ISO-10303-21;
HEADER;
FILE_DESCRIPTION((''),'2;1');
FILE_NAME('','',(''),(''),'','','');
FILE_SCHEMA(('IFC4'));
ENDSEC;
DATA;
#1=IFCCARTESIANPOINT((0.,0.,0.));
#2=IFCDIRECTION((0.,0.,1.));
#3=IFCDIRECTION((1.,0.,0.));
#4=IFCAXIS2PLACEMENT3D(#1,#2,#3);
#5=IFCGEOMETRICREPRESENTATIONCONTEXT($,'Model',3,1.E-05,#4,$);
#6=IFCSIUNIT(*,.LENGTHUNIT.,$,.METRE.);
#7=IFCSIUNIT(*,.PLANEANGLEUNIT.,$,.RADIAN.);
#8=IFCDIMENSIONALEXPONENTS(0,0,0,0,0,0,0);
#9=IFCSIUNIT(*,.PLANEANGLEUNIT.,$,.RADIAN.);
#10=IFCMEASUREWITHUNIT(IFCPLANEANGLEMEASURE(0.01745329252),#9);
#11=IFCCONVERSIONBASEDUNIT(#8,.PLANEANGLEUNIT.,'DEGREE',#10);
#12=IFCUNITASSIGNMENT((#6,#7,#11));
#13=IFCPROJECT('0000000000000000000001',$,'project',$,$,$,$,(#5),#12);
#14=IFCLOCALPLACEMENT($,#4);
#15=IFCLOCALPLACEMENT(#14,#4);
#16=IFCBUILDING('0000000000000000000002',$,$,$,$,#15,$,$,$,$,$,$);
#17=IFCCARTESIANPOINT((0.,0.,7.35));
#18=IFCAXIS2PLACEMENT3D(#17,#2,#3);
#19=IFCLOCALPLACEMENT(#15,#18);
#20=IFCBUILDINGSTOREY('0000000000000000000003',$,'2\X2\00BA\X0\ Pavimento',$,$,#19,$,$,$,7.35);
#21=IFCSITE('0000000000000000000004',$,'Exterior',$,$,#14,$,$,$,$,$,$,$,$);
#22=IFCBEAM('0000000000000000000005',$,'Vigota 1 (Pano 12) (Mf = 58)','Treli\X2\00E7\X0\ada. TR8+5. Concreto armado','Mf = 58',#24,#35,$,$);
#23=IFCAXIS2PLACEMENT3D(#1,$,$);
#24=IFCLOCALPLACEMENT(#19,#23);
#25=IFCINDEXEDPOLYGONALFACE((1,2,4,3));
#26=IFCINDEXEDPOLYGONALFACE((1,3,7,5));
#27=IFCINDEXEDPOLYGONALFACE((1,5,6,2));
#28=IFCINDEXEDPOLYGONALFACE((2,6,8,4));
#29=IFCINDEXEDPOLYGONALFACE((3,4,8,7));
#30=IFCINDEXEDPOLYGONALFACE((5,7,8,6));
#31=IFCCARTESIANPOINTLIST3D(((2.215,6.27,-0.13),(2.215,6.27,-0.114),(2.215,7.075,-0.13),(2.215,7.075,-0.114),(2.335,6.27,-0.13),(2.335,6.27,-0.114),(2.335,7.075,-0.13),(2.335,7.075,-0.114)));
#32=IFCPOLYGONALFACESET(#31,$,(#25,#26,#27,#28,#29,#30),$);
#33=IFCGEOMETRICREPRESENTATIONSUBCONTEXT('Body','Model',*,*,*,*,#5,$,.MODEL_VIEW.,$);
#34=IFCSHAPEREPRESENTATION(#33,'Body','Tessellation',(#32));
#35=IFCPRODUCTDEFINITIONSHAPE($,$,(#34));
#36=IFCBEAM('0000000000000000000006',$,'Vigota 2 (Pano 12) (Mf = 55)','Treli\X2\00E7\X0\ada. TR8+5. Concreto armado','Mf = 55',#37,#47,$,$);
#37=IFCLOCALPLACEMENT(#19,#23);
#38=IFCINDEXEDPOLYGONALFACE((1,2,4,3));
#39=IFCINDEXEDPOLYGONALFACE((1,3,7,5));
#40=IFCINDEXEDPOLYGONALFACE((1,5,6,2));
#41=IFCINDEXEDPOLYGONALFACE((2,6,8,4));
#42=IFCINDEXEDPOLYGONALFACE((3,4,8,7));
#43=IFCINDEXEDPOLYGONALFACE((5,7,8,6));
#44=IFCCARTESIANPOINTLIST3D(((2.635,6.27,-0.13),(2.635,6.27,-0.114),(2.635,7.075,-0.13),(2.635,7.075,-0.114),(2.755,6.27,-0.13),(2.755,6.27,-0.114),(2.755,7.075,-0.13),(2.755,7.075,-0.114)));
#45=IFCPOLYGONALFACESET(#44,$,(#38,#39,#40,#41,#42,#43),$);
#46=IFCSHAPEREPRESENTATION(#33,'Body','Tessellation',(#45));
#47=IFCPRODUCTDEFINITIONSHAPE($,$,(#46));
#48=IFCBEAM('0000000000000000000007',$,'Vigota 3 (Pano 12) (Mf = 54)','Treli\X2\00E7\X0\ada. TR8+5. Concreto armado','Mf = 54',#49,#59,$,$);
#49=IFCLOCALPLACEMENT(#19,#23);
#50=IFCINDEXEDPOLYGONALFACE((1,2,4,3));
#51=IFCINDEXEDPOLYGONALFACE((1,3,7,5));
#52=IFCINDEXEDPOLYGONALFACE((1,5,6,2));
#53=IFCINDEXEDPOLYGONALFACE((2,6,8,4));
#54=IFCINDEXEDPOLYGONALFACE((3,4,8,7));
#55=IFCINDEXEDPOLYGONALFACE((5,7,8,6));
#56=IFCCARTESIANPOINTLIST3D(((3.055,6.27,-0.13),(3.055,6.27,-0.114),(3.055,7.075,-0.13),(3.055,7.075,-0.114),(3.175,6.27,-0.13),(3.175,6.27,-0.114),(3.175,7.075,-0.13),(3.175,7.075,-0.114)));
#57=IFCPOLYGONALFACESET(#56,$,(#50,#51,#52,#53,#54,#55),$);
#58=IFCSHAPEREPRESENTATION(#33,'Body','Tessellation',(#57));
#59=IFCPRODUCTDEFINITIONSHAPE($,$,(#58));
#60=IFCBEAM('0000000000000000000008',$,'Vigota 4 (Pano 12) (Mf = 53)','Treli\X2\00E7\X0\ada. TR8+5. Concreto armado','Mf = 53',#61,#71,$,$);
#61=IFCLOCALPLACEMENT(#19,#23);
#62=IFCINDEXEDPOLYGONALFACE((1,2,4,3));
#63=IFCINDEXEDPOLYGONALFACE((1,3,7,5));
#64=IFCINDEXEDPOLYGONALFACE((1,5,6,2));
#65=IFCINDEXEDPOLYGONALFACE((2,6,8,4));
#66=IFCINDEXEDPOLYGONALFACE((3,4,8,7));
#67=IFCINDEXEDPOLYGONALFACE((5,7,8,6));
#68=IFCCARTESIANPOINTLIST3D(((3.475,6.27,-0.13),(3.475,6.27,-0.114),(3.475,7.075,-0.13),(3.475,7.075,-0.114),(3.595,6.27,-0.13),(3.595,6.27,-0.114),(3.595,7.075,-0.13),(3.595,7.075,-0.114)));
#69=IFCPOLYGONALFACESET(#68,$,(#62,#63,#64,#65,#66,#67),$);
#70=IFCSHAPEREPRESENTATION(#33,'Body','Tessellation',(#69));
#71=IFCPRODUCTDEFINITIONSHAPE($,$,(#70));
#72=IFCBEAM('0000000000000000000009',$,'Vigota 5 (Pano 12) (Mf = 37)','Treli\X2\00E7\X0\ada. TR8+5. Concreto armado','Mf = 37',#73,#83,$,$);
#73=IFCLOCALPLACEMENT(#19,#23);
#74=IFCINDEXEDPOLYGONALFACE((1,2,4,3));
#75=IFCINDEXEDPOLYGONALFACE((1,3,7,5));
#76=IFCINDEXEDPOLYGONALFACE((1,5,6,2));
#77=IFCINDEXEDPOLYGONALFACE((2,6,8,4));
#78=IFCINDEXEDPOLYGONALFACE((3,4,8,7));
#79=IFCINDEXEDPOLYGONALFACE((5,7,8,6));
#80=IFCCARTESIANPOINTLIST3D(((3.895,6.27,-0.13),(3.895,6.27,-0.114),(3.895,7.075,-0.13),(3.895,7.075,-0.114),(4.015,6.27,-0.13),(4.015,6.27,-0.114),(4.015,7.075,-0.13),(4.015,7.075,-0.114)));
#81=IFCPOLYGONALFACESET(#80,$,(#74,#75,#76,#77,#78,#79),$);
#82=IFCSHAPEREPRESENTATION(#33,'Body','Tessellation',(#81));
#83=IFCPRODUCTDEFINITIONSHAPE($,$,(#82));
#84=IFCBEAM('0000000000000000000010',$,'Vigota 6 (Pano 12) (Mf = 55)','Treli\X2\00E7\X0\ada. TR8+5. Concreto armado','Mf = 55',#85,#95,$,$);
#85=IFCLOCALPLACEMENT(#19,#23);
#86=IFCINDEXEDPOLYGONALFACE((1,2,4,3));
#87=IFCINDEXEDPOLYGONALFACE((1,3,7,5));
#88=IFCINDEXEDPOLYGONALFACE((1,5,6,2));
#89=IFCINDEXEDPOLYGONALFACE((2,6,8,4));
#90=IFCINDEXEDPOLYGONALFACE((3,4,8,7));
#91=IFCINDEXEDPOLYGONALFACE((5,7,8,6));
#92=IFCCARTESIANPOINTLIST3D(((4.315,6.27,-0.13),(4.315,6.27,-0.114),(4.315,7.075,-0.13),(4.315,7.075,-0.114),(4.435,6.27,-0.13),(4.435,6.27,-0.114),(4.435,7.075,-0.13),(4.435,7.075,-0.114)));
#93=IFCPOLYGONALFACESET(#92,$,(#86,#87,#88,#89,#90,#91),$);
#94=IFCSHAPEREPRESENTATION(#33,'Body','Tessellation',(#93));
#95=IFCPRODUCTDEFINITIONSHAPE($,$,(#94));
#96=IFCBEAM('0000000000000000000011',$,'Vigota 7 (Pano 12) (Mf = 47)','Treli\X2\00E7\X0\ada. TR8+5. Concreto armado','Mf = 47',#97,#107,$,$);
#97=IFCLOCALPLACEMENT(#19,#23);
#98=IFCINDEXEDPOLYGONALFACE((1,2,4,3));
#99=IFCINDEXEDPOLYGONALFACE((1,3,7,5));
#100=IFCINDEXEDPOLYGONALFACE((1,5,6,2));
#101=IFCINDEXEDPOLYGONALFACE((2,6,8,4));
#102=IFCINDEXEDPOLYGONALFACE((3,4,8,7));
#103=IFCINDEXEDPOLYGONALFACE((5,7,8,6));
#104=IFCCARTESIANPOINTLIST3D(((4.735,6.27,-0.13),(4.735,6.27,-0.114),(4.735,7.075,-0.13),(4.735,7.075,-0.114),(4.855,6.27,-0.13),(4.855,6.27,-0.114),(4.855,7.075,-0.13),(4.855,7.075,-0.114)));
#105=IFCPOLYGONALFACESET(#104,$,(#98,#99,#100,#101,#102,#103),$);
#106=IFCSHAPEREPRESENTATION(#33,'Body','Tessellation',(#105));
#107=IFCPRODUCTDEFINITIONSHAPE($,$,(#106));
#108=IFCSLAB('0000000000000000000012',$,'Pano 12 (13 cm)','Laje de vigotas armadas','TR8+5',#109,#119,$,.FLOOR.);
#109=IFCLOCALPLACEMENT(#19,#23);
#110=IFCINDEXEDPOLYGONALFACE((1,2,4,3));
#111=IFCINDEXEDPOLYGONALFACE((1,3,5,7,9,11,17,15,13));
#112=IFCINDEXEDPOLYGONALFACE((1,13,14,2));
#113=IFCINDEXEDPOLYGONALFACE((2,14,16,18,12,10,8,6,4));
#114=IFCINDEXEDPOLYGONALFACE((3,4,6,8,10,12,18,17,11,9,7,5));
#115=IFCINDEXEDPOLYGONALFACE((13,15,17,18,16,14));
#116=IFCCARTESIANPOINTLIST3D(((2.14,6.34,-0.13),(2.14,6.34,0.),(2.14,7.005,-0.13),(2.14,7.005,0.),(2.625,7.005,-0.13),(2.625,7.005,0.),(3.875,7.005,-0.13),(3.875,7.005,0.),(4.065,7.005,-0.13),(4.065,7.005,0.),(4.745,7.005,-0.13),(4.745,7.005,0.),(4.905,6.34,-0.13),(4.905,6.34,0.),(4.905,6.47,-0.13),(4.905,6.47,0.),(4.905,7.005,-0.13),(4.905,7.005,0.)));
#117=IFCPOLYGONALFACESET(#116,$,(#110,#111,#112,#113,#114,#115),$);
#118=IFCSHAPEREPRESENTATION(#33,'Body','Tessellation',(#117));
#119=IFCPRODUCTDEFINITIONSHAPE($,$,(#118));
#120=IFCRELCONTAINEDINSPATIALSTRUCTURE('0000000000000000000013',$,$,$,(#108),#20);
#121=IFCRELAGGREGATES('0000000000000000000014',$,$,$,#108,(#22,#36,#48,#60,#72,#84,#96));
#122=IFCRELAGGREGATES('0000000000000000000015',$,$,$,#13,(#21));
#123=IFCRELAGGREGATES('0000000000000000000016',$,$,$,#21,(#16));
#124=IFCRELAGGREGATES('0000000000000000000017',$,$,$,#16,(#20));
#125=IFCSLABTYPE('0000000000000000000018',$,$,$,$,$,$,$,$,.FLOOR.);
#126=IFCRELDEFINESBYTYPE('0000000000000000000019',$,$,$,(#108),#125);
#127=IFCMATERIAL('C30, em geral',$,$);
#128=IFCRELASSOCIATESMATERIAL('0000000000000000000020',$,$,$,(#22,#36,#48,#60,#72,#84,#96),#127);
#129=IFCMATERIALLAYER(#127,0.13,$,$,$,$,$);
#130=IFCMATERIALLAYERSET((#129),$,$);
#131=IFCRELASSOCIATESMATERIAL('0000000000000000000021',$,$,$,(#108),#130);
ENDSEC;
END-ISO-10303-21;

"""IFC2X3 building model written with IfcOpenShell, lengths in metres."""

from ifc_helpers import new_model, entity, si_unit, converted_unit, frame, origin_with_axes, place, context, subcontext, project, spatial, polyline, outline, extrude, material, layer, layer_set, layer_usage, type_object, element, aggregate, save


model = new_model("IFC2X3")

# Units and contexts
model_context = context("Model", 3, precision=1e-05, world=origin_with_axes())
body_context = subcontext(model_context, "Body", "Model", "MODEL_VIEW")
ifc_project = project(units=[si_unit("LENGTHUNIT", "METRE"), si_unit("PLANEANGLEUNIT", "RADIAN"), converted_unit("PLANEANGLEUNIT", "DEGREE", entity("IfcPlaneAngleMeasure", 0.01745329252), si_unit("PLANEANGLEUNIT", "RADIAN"), dimensions=[0, 0, 0, 0, 0, 0, 0])], contexts=[model_context])

# Beams
ifc_material = material(Name="C30, em geral")
site_placement = place(None, origin_with_axes())
building_placement = place(site_placement, origin_with_axes())
storey_placement = place(building_placement, frame((0.0, 0.0, 7.35), z_axis=(0.0, 0.0, 1.0), x_axis=(1.0, 0.0, 0.0)))
beam_1_placement = place(storey_placement, frame((2.275, 6.27, -0.122), z_axis=(0.0, 1.0, 0.0), x_axis=(-1.0, 0.0, 0.0)))
beam_1 = element("IfcBeam", 1, at=beam_1_placement, material=ifc_material, Name="Vigota 1 (Pano 12) (Mf = 58)", Description="Treliçada. TR8+5. Concreto armado", ObjectType="Mf = 58", context=body_context, shape_type="SweptSolid", body=[
    extrude(outline(polyline([(0.06, 0.008), (-0.06, 0.008), (-0.06, -0.008), (0.06, -0.008), (0.06, 0.008)])), origin_with_axes(), (0.0, 0.0, 1.0), 0.805),
])
beam_2_placement = place(storey_placement, frame((2.695, 6.27, -0.122), z_axis=(0.0, 1.0, 0.0), x_axis=(-1.0, 0.0, 0.0)))
beam_2 = element("IfcBeam", 2, at=beam_2_placement, material=ifc_material, Name="Vigota 2 (Pano 12) (Mf = 55)", Description="Treliçada. TR8+5. Concreto armado", ObjectType="Mf = 55", context=body_context, shape_type="SweptSolid", body=[
    extrude(outline(polyline([(0.06, 0.008), (-0.06, 0.008), (-0.06, -0.008), (0.06, -0.008), (0.06, 0.008)])), origin_with_axes(), (0.0, 0.0, 1.0), 0.805),
])
beam_3_placement = place(storey_placement, frame((3.115, 6.27, -0.122), z_axis=(0.0, 1.0, 0.0), x_axis=(-1.0, 0.0, 0.0)))
beam_3 = element("IfcBeam", 3, at=beam_3_placement, material=ifc_material, Name="Vigota 3 (Pano 12) (Mf = 54)", Description="Treliçada. TR8+5. Concreto armado", ObjectType="Mf = 54", context=body_context, shape_type="SweptSolid", body=[
    extrude(outline(polyline([(0.06, 0.008), (-0.06, 0.008), (-0.06, -0.008), (0.06, -0.008), (0.06, 0.008)])), origin_with_axes(), (0.0, 0.0, 1.0), 0.805),
])
beam_4_placement = place(storey_placement, frame((3.535, 6.27, -0.122), z_axis=(0.0, 1.0, 0.0), x_axis=(-1.0, 0.0, 0.0)))
beam_4 = element("IfcBeam", 4, at=beam_4_placement, material=ifc_material, Name="Vigota 4 (Pano 12) (Mf = 53)", Description="Treliçada. TR8+5. Concreto armado", ObjectType="Mf = 53", context=body_context, shape_type="SweptSolid", body=[
    extrude(outline(polyline([(0.06, 0.008), (-0.06, 0.008), (-0.06, -0.008), (0.06, -0.008), (0.06, 0.008)])), origin_with_axes(), (0.0, 0.0, 1.0), 0.805),
])
beam_5_placement = place(storey_placement, frame((3.955, 6.27, -0.122), z_axis=(0.0, 1.0, 0.0), x_axis=(-1.0, 0.0, 0.0)))
beam_5 = element("IfcBeam", 5, at=beam_5_placement, material=ifc_material, Name="Vigota 5 (Pano 12) (Mf = 37)", Description="Treliçada. TR8+5. Concreto armado", ObjectType="Mf = 37", context=body_context, shape_type="SweptSolid", body=[
    extrude(outline(polyline([(0.06, 0.008), (-0.06, 0.008), (-0.06, -0.008), (0.06, -0.008), (0.06, 0.008)])), origin_with_axes(), (0.0, 0.0, 1.0), 0.805),
])
beam_6_placement = place(storey_placement, frame((4.375, 6.27, -0.122), z_axis=(0.0, 1.0, 0.0), x_axis=(-1.0, 0.0, 0.0)))
beam_6 = element("IfcBeam", 6, at=beam_6_placement, material=ifc_material, Name="Vigota 6 (Pano 12) (Mf = 55)", Description="Treliçada. TR8+5. Concreto armado", ObjectType="Mf = 55", context=body_context, shape_type="SweptSolid", body=[
    extrude(outline(polyline([(0.06, 0.008), (-0.06, 0.008), (-0.06, -0.008), (0.06, -0.008), (0.06, 0.008)])), origin_with_axes(), (0.0, 0.0, 1.0), 0.805),
])
beam_7_placement = place(storey_placement, frame((4.795, 6.27, -0.122), z_axis=(0.0, 1.0, 0.0), x_axis=(-1.0, 0.0, 0.0)))
beam_7 = element("IfcBeam", 7, at=beam_7_placement, material=ifc_material, Name="Vigota 7 (Pano 12) (Mf = 47)", Description="Treliçada. TR8+5. Concreto armado", ObjectType="Mf = 47", context=body_context, shape_type="SweptSolid", body=[
    extrude(outline(polyline([(0.06, 0.008), (-0.06, 0.008), (-0.06, -0.008), (0.06, -0.008), (0.06, 0.008)])), origin_with_axes(), (0.0, 0.0, 1.0), 0.805),
])

# Site, building, storey
site = spatial("IfcSite", under=ifc_project, at=site_placement, Name="Exterior")
building = spatial("IfcBuilding", under=site, at=building_placement)
storey = spatial("IfcBuildingStorey", under=building, at=storey_placement, Name="2º Pavimento", Elevation=7.35)

# Slab
ifc_layer_1 = layer(ifc_material, 0.13)
ifc_layer_set_1 = layer_set([ifc_layer_1])
ifc_layer_usage_1 = layer_usage(ifc_layer_set_1, "AXIS3", "POSITIVE", 0.0)
slab_type = type_object("IfcSlabType", PredefinedType="FLOOR")
slab_1_placement = place(storey_placement, frame((0.0, 0.0, -0.13), z_axis=(0.0, 0.0, 1.0), x_axis=(1.0, 0.0, 0.0)))
slab_1 = element("IfcSlab", 8, at=slab_1_placement, inside=storey, type_object=slab_type, material=ifc_layer_usage_1, Name="Pano 12 (13 cm)", Description="Laje de vigotas armadas", ObjectType="TR8+5", PredefinedType="FLOOR", context=body_context, shape_type="SweptSolid", body=[
    extrude(outline(polyline([(4.905, 7.005), (4.745, 7.005), (4.065, 7.005), (3.875, 7.005), (2.625, 7.005), (2.14, 7.005), (2.14, 6.34), (4.905, 6.34), (4.905, 6.47), (4.905, 7.005)])), origin_with_axes(), (0.0, 0.0, 1.0), 0.13),
])
aggregate(slab_1, [beam_1, beam_2, beam_3, beam_4, beam_5, beam_6, beam_7])

save(model, "model.ifc")
